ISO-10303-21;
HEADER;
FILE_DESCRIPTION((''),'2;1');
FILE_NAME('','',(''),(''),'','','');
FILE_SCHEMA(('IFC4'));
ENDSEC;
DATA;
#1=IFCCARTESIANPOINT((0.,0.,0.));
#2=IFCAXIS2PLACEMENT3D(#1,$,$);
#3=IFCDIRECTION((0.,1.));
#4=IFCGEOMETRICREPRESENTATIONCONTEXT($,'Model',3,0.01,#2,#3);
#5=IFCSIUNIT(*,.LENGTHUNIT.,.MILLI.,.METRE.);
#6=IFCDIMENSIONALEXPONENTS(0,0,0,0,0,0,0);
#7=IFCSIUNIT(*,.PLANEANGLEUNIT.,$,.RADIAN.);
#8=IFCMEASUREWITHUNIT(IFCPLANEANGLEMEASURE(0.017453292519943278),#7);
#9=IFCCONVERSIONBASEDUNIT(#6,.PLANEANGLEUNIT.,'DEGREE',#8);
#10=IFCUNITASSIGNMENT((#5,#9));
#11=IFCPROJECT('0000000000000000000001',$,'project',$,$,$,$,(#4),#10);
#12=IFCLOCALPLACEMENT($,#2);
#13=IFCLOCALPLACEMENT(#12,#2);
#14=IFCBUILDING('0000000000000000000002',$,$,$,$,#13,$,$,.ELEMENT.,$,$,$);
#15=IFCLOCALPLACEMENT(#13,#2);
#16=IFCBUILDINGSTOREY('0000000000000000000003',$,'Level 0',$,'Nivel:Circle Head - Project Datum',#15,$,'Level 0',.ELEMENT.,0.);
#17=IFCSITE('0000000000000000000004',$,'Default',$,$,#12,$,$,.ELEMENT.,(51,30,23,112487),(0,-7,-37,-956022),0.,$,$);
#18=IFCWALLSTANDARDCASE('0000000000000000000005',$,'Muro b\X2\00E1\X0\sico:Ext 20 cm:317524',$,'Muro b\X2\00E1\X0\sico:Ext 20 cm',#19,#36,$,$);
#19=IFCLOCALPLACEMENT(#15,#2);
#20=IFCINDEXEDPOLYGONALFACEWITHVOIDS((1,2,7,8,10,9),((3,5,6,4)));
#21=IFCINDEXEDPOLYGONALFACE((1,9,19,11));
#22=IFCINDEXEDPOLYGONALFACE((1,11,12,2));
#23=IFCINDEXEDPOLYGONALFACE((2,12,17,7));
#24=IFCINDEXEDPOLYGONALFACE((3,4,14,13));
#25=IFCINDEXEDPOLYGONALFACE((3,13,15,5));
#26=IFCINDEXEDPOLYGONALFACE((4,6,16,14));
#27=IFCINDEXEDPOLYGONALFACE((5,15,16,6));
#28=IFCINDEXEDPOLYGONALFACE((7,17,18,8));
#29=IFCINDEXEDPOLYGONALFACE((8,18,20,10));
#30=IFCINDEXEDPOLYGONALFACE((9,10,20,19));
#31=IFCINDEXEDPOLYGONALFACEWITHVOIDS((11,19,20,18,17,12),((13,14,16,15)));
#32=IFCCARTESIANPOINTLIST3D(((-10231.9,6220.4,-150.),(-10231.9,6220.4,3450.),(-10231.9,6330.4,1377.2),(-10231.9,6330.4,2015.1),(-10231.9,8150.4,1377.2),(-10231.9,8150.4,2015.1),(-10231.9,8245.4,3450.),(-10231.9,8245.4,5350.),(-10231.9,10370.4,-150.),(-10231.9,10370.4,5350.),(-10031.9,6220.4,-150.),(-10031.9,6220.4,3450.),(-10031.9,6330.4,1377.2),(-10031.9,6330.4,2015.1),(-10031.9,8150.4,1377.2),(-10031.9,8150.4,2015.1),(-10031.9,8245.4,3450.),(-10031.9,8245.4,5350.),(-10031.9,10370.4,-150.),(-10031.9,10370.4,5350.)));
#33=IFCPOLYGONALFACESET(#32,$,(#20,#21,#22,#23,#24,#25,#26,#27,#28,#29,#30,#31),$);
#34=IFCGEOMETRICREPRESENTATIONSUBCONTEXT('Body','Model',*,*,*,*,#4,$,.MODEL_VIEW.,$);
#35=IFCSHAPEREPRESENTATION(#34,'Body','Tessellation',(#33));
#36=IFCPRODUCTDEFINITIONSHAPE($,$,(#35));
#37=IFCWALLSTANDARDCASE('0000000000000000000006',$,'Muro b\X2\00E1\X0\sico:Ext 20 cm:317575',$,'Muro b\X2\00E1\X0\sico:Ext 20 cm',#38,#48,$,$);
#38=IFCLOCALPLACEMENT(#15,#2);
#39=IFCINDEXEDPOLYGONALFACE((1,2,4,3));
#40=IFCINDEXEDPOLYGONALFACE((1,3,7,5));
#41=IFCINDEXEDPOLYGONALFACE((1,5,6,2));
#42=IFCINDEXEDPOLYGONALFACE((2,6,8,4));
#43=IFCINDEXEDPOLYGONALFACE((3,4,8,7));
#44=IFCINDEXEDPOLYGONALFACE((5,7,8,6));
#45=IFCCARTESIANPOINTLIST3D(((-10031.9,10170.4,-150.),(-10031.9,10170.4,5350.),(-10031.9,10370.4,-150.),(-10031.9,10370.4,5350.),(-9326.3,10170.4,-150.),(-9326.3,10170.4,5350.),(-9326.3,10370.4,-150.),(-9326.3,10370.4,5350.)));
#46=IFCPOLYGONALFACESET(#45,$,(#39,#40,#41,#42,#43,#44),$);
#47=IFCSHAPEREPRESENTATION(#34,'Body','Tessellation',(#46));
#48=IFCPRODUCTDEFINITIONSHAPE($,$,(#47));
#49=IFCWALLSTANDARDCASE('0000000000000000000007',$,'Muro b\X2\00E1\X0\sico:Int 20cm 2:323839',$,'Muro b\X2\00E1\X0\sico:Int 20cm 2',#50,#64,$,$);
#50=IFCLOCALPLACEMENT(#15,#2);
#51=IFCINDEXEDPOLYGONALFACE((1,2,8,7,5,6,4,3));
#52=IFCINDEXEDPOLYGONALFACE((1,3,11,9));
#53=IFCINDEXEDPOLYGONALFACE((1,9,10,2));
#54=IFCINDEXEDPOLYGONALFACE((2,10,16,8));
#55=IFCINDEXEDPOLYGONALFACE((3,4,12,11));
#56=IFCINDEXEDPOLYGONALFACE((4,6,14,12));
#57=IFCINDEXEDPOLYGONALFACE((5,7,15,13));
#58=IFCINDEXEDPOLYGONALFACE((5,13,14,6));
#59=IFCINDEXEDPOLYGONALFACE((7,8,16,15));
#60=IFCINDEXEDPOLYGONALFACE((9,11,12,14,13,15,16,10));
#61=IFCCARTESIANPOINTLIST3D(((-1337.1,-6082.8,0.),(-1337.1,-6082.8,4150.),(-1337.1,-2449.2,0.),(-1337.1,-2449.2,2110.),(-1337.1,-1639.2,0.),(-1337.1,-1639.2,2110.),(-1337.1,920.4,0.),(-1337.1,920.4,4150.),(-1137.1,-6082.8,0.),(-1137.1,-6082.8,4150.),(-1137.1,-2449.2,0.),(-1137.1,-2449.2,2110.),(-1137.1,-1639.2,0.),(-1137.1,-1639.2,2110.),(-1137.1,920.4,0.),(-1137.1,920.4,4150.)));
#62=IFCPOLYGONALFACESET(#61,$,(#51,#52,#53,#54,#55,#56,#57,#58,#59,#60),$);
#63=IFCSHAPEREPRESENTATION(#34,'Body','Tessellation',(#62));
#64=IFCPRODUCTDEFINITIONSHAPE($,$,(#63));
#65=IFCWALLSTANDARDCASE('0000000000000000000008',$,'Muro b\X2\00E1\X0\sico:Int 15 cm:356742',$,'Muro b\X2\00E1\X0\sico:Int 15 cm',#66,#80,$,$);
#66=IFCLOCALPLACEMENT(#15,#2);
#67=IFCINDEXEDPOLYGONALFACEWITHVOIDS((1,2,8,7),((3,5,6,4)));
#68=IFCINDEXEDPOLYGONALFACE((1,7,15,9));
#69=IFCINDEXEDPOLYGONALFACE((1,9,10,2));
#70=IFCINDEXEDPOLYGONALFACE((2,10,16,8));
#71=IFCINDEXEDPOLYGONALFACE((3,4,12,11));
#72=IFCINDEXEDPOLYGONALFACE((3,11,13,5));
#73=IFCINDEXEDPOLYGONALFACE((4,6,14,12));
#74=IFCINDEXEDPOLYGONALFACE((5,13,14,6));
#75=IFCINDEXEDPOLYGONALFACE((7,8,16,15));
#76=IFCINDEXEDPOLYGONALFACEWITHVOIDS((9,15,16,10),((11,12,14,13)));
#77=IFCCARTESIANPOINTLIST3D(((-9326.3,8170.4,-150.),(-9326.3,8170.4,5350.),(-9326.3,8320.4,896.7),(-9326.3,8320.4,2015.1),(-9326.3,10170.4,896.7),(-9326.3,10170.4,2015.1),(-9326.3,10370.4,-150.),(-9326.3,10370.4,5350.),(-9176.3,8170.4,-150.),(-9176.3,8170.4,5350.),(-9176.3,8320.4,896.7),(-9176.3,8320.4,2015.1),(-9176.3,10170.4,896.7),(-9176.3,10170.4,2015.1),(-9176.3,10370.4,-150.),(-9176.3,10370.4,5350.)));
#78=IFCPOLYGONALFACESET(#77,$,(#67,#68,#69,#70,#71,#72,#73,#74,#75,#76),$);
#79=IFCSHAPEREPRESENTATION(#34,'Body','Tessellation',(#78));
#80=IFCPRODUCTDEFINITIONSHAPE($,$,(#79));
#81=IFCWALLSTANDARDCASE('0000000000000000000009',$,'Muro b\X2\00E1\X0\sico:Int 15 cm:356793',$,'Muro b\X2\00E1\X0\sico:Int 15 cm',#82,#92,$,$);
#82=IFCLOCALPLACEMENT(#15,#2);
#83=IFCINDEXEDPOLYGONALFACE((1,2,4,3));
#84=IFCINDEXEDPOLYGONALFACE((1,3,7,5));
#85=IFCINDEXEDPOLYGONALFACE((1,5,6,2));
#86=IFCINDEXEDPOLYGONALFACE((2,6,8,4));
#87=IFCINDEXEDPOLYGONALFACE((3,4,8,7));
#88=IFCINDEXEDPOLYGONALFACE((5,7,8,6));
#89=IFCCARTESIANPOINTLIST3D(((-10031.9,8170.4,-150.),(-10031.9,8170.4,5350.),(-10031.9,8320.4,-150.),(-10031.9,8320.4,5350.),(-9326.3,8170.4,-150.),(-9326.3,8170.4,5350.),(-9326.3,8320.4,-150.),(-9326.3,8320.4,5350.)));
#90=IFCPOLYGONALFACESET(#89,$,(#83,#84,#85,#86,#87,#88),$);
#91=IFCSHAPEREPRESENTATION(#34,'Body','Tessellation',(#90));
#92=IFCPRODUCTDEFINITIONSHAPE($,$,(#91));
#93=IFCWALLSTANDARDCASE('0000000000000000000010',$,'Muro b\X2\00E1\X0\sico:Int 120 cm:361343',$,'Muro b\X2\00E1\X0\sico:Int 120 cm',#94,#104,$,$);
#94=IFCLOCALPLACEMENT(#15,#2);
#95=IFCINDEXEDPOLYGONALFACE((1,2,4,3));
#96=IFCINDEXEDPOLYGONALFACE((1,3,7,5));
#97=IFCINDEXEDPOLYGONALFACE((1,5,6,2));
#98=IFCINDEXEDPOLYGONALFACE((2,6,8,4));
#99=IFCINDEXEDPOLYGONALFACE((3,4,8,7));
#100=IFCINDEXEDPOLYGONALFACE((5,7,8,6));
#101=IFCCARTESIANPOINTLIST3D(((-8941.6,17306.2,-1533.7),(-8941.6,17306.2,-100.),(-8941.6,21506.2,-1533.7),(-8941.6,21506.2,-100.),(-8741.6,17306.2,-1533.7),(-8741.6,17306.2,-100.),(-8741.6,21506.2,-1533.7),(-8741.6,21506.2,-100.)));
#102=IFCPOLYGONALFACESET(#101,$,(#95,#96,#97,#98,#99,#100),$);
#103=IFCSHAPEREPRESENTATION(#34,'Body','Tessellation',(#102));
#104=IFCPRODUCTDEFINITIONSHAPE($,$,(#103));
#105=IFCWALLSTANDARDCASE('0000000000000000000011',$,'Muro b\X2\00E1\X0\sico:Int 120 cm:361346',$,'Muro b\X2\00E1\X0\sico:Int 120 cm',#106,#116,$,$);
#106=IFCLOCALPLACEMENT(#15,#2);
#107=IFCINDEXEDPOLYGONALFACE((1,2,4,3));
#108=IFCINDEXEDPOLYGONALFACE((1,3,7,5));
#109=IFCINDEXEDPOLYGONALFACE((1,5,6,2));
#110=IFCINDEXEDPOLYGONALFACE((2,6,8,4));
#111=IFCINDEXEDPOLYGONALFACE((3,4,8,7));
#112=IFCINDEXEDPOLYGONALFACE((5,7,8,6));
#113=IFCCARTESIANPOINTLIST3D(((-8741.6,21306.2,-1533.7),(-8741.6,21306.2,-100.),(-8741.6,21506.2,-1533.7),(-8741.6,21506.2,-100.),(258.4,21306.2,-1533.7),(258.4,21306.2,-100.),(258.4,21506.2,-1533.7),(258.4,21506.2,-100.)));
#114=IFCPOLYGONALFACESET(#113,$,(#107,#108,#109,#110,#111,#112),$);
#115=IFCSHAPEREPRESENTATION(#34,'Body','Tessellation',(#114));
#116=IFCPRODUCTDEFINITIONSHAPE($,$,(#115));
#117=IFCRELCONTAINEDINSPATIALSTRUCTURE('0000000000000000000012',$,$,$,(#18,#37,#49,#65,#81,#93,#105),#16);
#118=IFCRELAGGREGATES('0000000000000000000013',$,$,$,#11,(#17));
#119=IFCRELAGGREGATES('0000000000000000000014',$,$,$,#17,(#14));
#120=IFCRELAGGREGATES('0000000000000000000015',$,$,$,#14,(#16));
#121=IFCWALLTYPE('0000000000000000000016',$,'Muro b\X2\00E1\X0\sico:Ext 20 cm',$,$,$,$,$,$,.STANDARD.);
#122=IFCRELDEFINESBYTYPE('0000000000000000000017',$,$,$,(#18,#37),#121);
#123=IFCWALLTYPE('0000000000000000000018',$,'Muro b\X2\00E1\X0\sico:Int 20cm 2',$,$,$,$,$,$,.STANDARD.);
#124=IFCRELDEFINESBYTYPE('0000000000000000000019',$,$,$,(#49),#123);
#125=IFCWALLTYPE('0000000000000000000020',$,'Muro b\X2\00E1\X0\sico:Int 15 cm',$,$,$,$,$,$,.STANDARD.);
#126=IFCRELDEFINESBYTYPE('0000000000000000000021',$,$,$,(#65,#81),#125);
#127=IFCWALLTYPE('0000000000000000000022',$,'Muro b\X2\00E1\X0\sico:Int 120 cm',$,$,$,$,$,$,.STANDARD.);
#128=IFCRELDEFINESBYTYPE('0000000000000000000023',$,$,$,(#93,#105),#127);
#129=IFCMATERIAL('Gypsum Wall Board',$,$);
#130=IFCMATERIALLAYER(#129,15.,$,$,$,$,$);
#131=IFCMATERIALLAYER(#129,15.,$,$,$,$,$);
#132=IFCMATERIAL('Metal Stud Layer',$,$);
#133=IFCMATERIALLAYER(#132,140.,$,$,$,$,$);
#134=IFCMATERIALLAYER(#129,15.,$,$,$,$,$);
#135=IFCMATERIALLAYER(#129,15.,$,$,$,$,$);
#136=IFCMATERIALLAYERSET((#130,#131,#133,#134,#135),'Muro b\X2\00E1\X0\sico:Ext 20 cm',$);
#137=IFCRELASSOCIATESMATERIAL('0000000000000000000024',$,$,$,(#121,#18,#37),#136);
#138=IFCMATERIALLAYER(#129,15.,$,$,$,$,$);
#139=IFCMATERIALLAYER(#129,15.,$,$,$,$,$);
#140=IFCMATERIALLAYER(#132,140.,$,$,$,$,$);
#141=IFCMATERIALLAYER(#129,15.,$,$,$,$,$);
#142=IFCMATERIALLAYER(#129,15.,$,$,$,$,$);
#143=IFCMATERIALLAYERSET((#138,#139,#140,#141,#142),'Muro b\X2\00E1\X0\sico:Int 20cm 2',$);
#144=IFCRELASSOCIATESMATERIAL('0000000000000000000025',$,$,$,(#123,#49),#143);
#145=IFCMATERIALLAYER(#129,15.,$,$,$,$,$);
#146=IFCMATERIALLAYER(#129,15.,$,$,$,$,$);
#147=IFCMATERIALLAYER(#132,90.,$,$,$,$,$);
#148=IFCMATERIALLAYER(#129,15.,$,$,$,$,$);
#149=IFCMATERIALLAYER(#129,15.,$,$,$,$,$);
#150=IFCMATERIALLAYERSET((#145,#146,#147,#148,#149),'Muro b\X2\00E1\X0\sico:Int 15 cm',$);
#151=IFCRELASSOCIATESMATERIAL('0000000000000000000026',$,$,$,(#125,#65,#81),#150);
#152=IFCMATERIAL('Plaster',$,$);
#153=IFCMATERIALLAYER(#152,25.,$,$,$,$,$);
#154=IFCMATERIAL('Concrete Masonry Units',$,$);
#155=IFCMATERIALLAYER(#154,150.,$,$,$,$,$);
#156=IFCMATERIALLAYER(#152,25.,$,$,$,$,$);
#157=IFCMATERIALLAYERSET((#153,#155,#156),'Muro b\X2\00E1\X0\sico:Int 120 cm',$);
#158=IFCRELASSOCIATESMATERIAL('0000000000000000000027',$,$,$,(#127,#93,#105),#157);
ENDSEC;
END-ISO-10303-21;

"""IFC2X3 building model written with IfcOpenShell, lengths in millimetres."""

from ifc_helpers import new_model, entity, si_unit, converted_unit, direction, frame, frame_2d, origin, origin_2d_with_axis, place, context, subcontext, project, spatial, rectangle, extrude, material, layer, layer_set, layer_usage, type_object, element, save


model = new_model("IFC2X3")

# Units and contexts
model_context = context("Model", 3, precision=0.01, world=origin(), true_north=direction((0.0, 1.0)))
body_context = subcontext(model_context, "Body", "Model", "MODEL_VIEW")
ifc_project = project(units=[si_unit("LENGTHUNIT", "METRE", prefix="MILLI"), converted_unit("PLANEANGLEUNIT", "DEGREE", entity("IfcPlaneAngleMeasure", 0.017453292519943278), si_unit("PLANEANGLEUNIT", "RADIAN"), dimensions=[0, 0, 0, 0, 0, 0, 0])], contexts=[model_context])

# Site, building, storey
site_placement = place(None, origin())
site = spatial("IfcSite", under=ifc_project, at=site_placement, Name="Default", CompositionType="ELEMENT", RefLatitude=(51, 30, 23, 112487), RefLongitude=(0, -7, -37, -956022), RefElevation=0.0)
building_placement = place(site_placement, origin())
building = spatial("IfcBuilding", under=site, at=building_placement, CompositionType="ELEMENT")
storey_placement = place(building_placement, origin())
storey = spatial("IfcBuildingStorey", under=building, at=storey_placement, Name="Level 0", ObjectType="Nivel:Circle Head - Project Datum", LongName="Level 0", CompositionType="ELEMENT", Elevation=0.0)

# Shared definitions
ifc_material_1 = material(Name="Gypsum Wall Board")
ifc_layer_1 = layer(ifc_material_1, 15.0)
ifc_layer_2 = layer(ifc_material_1, 15.0)
ifc_material_2 = material(Name="Metal Stud Layer")
ifc_layer_3 = layer(ifc_material_2, 140.0)
ifc_layer_4 = layer(ifc_material_1, 15.0)
ifc_layer_5 = layer(ifc_material_1, 15.0)
ifc_layer_set_1 = layer_set([ifc_layer_1, ifc_layer_2, ifc_layer_3, ifc_layer_4, ifc_layer_5], Name="Muro básico:Ext 20 cm")
wall_type_1 = type_object("IfcWallType", Name="Muro básico:Ext 20 cm", PredefinedType="STANDARD", material=ifc_layer_set_1)

# Wall, openings
ifc_layer_usage_1 = layer_usage(ifc_layer_set_1, "AXIS2", "NEGATIVE", 100.0)
wall_1_placement = place(storey_placement, frame((-10131.9, 6220.4, -150.0), z_axis=(0.0, 0.0, 1.0), x_axis=(0.0, 1.0, 0.0)))
wall_1 = element("IfcWallStandardCase", 1, at=wall_1_placement, inside=storey, type_object=wall_type_1, material=ifc_layer_usage_1, Name="Muro básico:Ext 20 cm:317524", ObjectType="Muro básico:Ext 20 cm", context=body_context, shape_type="SweptSolid", body=[
    extrude(rectangle(XDim=4150.0, YDim=200.0, at=frame_2d((2075.0, 0.0), x_axis=(-1.0, 0.0))), origin(), (0.0, 0.0, 1.0), 5500.0),
])
opening_1_placement = place(wall_1_placement, origin())
element("IfcOpeningElement", 2, at=opening_1_placement, cuts=wall_1, ObjectType="Opening", context=body_context, shape_type="SweptSolid", body=[
    extrude(rectangle(XDim=637.9, YDim=1820.0, at=frame_2d((0.0, 0.0), x_axis=(1.0, 0.0))), frame((1020.0, -100.0, 1846.1), z_axis=(0.0, 1.0, 0.0), x_axis=(0.0, 0.0, -1.0)), (0.0, 0.0, 1.0), 200.0),
])
opening_2_placement = place(wall_1_placement, origin())
element("IfcOpeningElement", 3, at=opening_2_placement, cuts=wall_1, ObjectType="Opening", context=body_context, shape_type="SweptSolid", body=[
    extrude(rectangle(XDim=1900.0, YDim=2025.0, at=frame_2d((0.0, 0.0), x_axis=(0.0, 1.0))), frame((1012.5, 100.0, 4550.0), z_axis=(0.0, -1.0, 0.0), x_axis=(-1.0, 0.0, 0.0)), (0.0, 0.0, 1.0), 200.0),
])

# Wall
ifc_layer_usage_2 = layer_usage(ifc_layer_set_1, "AXIS2", "NEGATIVE", 100.0)
wall_2_placement = place(storey_placement, frame((-10031.9, 10270.4, -150.0)))
element("IfcWallStandardCase", 4, at=wall_2_placement, inside=storey, type_object=wall_type_1, material=ifc_layer_usage_2, Name="Muro básico:Ext 20 cm:317575", ObjectType="Muro básico:Ext 20 cm", context=body_context, shape_type="SweptSolid", body=[
    extrude(rectangle(XDim=705.6, YDim=200.0, at=frame_2d((352.8, 0.0), x_axis=(-1.0, 0.0))), origin(), (0.0, 0.0, 1.0), 5500.0),
])

# Walls, openings
ifc_layer_6 = layer(ifc_material_1, 15.0)
ifc_layer_7 = layer(ifc_material_1, 15.0)
ifc_layer_8 = layer(ifc_material_2, 140.0)
ifc_layer_9 = layer(ifc_material_1, 15.0)
ifc_layer_10 = layer(ifc_material_1, 15.0)
ifc_layer_set_2 = layer_set([ifc_layer_6, ifc_layer_7, ifc_layer_8, ifc_layer_9, ifc_layer_10], Name="Muro básico:Int 20cm 2")
ifc_layer_usage_3 = layer_usage(ifc_layer_set_2, "AXIS2", "NEGATIVE", 100.0)
wall_type_2 = type_object("IfcWallType", Name="Muro básico:Int 20cm 2", PredefinedType="STANDARD", material=ifc_layer_set_2)
wall_3_placement = place(storey_placement, frame((-1237.1, 920.4, 0.0), z_axis=(0.0, 0.0, 1.0), x_axis=(0.0, -1.0, 0.0)))
wall_3 = element("IfcWallStandardCase", 5, at=wall_3_placement, inside=storey, type_object=wall_type_2, material=ifc_layer_usage_3, Name="Muro básico:Int 20cm 2:323839", ObjectType="Muro básico:Int 20cm 2", context=body_context, shape_type="SweptSolid", body=[
    extrude(rectangle(XDim=7003.2, YDim=200.0, at=frame_2d((3501.6, 0.0), x_axis=(-1.0, 0.0))), origin(), (0.0, 0.0, 1.0), 4150.0),
])
opening_3_placement = place(wall_3_placement, frame((2559.6, -100.0, 0.0)))
element("IfcOpeningElement", 6, at=opening_3_placement, cuts=wall_3, ObjectType="Opening", context=body_context, shape_type="SweptSolid", body=[
    extrude(rectangle(XDim=2110.0, YDim=810.0, at=frame_2d((1055.0, 405.0), x_axis=(1.0, 0.0))), frame((0.0, 0.0, 0.0), z_axis=(0.0, 1.0, 0.0), x_axis=(0.0, 0.0, 1.0)), (0.0, 0.0, 1.0), 200.0),
])
ifc_layer_11 = layer(ifc_material_1, 15.0)
ifc_layer_12 = layer(ifc_material_1, 15.0)
ifc_layer_13 = layer(ifc_material_2, 90.0)
ifc_layer_14 = layer(ifc_material_1, 15.0)
ifc_layer_15 = layer(ifc_material_1, 15.0)
ifc_layer_set_3 = layer_set([ifc_layer_11, ifc_layer_12, ifc_layer_13, ifc_layer_14, ifc_layer_15], Name="Muro básico:Int 15 cm")
ifc_layer_usage_4 = layer_usage(ifc_layer_set_3, "AXIS2", "POSITIVE", -75.0)
wall_type_3 = type_object("IfcWallType", Name="Muro básico:Int 15 cm", PredefinedType="STANDARD", material=ifc_layer_set_3)
wall_4_placement = place(storey_placement, frame((-9251.3, 10370.4, -150.0), z_axis=(0.0, 0.0, 1.0), x_axis=(0.0, -1.0, 0.0)))
wall_4 = element("IfcWallStandardCase", 7, at=wall_4_placement, inside=storey, type_object=wall_type_3, material=ifc_layer_usage_4, Name="Muro básico:Int 15 cm:356742", ObjectType="Muro básico:Int 15 cm", context=body_context, shape_type="SweptSolid", body=[
    extrude(rectangle(XDim=2200.0, YDim=150.0, at=frame_2d((1100.0, 0.0), x_axis=(-1.0, 0.0))), origin(), (0.0, 0.0, 1.0), 5500.0),
])
opening_4_placement = place(wall_4_placement, origin())
element("IfcOpeningElement", 8, at=opening_4_placement, cuts=wall_4, ObjectType="Opening", context=body_context, shape_type="SweptSolid", body=[
    extrude(rectangle(XDim=1118.4, YDim=1850.0, at=origin_2d_with_axis()), frame((1125.0, -75.0, 1605.9), z_axis=(0.0, 1.0, 0.0), x_axis=(0.0, 0.0, -1.0)), (0.0, 0.0, 1.0), 150.0),
])

# Walls
ifc_layer_usage_5 = layer_usage(ifc_layer_set_3, "AXIS2", "POSITIVE", -75.0)
wall_5_placement = place(storey_placement, frame((-9326.3, 8245.4, -150.0), z_axis=(0.0, 0.0, 1.0), x_axis=(-1.0, 0.0, 0.0)))
element("IfcWallStandardCase", 9, at=wall_5_placement, inside=storey, type_object=wall_type_3, material=ifc_layer_usage_5, Name="Muro básico:Int 15 cm:356793", ObjectType="Muro básico:Int 15 cm", context=body_context, shape_type="SweptSolid", body=[
    extrude(rectangle(XDim=705.6, YDim=150.0, at=frame_2d((352.8, 0.0), x_axis=(-1.0, 0.0))), origin(), (0.0, 0.0, 1.0), 5500.0),
])
ifc_material_3 = material(Name="Plaster")
ifc_layer_16 = layer(ifc_material_3, 25.0)
ifc_material_4 = material(Name="Concrete Masonry Units")
ifc_layer_17 = layer(ifc_material_4, 150.0)
ifc_layer_18 = layer(ifc_material_3, 25.0)
ifc_layer_set_4 = layer_set([ifc_layer_16, ifc_layer_17, ifc_layer_18], Name="Muro básico:Int 120 cm")
ifc_layer_usage_6 = layer_usage(ifc_layer_set_4, "AXIS2", "NEGATIVE", 100.0)
wall_type_4 = type_object("IfcWallType", Name="Muro básico:Int 120 cm", PredefinedType="STANDARD", material=ifc_layer_set_4)
wall_6_placement = place(storey_placement, frame((-8841.6, 17306.2, -1533.7), z_axis=(0.0, 0.0, 1.0), x_axis=(0.0, 1.0, 0.0)))
element("IfcWallStandardCase", 10, at=wall_6_placement, inside=storey, type_object=wall_type_4, material=ifc_layer_usage_6, Name="Muro básico:Int 120 cm:361343", ObjectType="Muro básico:Int 120 cm", context=body_context, shape_type="SweptSolid", body=[
    extrude(rectangle(XDim=4200.0, YDim=200.0, at=frame_2d((2100.0, 0.0), x_axis=(-1.0, 0.0))), origin(), (0.0, 0.0, 1.0), 1433.7),
])
ifc_layer_usage_7 = layer_usage(ifc_layer_set_4, "AXIS2", "NEGATIVE", 100.0)
wall_7_placement = place(storey_placement, frame((-8741.6, 21406.2, -1533.7)))
element("IfcWallStandardCase", 11, at=wall_7_placement, inside=storey, type_object=wall_type_4, material=ifc_layer_usage_7, Name="Muro básico:Int 120 cm:361346", ObjectType="Muro básico:Int 120 cm", context=body_context, shape_type="SweptSolid", body=[
    extrude(rectangle(XDim=9000.0, YDim=200.0, at=frame_2d((4500.0, 0.0), x_axis=(-1.0, 0.0))), origin(), (0.0, 0.0, 1.0), 1433.7),
])

save(model, "model.ifc")
